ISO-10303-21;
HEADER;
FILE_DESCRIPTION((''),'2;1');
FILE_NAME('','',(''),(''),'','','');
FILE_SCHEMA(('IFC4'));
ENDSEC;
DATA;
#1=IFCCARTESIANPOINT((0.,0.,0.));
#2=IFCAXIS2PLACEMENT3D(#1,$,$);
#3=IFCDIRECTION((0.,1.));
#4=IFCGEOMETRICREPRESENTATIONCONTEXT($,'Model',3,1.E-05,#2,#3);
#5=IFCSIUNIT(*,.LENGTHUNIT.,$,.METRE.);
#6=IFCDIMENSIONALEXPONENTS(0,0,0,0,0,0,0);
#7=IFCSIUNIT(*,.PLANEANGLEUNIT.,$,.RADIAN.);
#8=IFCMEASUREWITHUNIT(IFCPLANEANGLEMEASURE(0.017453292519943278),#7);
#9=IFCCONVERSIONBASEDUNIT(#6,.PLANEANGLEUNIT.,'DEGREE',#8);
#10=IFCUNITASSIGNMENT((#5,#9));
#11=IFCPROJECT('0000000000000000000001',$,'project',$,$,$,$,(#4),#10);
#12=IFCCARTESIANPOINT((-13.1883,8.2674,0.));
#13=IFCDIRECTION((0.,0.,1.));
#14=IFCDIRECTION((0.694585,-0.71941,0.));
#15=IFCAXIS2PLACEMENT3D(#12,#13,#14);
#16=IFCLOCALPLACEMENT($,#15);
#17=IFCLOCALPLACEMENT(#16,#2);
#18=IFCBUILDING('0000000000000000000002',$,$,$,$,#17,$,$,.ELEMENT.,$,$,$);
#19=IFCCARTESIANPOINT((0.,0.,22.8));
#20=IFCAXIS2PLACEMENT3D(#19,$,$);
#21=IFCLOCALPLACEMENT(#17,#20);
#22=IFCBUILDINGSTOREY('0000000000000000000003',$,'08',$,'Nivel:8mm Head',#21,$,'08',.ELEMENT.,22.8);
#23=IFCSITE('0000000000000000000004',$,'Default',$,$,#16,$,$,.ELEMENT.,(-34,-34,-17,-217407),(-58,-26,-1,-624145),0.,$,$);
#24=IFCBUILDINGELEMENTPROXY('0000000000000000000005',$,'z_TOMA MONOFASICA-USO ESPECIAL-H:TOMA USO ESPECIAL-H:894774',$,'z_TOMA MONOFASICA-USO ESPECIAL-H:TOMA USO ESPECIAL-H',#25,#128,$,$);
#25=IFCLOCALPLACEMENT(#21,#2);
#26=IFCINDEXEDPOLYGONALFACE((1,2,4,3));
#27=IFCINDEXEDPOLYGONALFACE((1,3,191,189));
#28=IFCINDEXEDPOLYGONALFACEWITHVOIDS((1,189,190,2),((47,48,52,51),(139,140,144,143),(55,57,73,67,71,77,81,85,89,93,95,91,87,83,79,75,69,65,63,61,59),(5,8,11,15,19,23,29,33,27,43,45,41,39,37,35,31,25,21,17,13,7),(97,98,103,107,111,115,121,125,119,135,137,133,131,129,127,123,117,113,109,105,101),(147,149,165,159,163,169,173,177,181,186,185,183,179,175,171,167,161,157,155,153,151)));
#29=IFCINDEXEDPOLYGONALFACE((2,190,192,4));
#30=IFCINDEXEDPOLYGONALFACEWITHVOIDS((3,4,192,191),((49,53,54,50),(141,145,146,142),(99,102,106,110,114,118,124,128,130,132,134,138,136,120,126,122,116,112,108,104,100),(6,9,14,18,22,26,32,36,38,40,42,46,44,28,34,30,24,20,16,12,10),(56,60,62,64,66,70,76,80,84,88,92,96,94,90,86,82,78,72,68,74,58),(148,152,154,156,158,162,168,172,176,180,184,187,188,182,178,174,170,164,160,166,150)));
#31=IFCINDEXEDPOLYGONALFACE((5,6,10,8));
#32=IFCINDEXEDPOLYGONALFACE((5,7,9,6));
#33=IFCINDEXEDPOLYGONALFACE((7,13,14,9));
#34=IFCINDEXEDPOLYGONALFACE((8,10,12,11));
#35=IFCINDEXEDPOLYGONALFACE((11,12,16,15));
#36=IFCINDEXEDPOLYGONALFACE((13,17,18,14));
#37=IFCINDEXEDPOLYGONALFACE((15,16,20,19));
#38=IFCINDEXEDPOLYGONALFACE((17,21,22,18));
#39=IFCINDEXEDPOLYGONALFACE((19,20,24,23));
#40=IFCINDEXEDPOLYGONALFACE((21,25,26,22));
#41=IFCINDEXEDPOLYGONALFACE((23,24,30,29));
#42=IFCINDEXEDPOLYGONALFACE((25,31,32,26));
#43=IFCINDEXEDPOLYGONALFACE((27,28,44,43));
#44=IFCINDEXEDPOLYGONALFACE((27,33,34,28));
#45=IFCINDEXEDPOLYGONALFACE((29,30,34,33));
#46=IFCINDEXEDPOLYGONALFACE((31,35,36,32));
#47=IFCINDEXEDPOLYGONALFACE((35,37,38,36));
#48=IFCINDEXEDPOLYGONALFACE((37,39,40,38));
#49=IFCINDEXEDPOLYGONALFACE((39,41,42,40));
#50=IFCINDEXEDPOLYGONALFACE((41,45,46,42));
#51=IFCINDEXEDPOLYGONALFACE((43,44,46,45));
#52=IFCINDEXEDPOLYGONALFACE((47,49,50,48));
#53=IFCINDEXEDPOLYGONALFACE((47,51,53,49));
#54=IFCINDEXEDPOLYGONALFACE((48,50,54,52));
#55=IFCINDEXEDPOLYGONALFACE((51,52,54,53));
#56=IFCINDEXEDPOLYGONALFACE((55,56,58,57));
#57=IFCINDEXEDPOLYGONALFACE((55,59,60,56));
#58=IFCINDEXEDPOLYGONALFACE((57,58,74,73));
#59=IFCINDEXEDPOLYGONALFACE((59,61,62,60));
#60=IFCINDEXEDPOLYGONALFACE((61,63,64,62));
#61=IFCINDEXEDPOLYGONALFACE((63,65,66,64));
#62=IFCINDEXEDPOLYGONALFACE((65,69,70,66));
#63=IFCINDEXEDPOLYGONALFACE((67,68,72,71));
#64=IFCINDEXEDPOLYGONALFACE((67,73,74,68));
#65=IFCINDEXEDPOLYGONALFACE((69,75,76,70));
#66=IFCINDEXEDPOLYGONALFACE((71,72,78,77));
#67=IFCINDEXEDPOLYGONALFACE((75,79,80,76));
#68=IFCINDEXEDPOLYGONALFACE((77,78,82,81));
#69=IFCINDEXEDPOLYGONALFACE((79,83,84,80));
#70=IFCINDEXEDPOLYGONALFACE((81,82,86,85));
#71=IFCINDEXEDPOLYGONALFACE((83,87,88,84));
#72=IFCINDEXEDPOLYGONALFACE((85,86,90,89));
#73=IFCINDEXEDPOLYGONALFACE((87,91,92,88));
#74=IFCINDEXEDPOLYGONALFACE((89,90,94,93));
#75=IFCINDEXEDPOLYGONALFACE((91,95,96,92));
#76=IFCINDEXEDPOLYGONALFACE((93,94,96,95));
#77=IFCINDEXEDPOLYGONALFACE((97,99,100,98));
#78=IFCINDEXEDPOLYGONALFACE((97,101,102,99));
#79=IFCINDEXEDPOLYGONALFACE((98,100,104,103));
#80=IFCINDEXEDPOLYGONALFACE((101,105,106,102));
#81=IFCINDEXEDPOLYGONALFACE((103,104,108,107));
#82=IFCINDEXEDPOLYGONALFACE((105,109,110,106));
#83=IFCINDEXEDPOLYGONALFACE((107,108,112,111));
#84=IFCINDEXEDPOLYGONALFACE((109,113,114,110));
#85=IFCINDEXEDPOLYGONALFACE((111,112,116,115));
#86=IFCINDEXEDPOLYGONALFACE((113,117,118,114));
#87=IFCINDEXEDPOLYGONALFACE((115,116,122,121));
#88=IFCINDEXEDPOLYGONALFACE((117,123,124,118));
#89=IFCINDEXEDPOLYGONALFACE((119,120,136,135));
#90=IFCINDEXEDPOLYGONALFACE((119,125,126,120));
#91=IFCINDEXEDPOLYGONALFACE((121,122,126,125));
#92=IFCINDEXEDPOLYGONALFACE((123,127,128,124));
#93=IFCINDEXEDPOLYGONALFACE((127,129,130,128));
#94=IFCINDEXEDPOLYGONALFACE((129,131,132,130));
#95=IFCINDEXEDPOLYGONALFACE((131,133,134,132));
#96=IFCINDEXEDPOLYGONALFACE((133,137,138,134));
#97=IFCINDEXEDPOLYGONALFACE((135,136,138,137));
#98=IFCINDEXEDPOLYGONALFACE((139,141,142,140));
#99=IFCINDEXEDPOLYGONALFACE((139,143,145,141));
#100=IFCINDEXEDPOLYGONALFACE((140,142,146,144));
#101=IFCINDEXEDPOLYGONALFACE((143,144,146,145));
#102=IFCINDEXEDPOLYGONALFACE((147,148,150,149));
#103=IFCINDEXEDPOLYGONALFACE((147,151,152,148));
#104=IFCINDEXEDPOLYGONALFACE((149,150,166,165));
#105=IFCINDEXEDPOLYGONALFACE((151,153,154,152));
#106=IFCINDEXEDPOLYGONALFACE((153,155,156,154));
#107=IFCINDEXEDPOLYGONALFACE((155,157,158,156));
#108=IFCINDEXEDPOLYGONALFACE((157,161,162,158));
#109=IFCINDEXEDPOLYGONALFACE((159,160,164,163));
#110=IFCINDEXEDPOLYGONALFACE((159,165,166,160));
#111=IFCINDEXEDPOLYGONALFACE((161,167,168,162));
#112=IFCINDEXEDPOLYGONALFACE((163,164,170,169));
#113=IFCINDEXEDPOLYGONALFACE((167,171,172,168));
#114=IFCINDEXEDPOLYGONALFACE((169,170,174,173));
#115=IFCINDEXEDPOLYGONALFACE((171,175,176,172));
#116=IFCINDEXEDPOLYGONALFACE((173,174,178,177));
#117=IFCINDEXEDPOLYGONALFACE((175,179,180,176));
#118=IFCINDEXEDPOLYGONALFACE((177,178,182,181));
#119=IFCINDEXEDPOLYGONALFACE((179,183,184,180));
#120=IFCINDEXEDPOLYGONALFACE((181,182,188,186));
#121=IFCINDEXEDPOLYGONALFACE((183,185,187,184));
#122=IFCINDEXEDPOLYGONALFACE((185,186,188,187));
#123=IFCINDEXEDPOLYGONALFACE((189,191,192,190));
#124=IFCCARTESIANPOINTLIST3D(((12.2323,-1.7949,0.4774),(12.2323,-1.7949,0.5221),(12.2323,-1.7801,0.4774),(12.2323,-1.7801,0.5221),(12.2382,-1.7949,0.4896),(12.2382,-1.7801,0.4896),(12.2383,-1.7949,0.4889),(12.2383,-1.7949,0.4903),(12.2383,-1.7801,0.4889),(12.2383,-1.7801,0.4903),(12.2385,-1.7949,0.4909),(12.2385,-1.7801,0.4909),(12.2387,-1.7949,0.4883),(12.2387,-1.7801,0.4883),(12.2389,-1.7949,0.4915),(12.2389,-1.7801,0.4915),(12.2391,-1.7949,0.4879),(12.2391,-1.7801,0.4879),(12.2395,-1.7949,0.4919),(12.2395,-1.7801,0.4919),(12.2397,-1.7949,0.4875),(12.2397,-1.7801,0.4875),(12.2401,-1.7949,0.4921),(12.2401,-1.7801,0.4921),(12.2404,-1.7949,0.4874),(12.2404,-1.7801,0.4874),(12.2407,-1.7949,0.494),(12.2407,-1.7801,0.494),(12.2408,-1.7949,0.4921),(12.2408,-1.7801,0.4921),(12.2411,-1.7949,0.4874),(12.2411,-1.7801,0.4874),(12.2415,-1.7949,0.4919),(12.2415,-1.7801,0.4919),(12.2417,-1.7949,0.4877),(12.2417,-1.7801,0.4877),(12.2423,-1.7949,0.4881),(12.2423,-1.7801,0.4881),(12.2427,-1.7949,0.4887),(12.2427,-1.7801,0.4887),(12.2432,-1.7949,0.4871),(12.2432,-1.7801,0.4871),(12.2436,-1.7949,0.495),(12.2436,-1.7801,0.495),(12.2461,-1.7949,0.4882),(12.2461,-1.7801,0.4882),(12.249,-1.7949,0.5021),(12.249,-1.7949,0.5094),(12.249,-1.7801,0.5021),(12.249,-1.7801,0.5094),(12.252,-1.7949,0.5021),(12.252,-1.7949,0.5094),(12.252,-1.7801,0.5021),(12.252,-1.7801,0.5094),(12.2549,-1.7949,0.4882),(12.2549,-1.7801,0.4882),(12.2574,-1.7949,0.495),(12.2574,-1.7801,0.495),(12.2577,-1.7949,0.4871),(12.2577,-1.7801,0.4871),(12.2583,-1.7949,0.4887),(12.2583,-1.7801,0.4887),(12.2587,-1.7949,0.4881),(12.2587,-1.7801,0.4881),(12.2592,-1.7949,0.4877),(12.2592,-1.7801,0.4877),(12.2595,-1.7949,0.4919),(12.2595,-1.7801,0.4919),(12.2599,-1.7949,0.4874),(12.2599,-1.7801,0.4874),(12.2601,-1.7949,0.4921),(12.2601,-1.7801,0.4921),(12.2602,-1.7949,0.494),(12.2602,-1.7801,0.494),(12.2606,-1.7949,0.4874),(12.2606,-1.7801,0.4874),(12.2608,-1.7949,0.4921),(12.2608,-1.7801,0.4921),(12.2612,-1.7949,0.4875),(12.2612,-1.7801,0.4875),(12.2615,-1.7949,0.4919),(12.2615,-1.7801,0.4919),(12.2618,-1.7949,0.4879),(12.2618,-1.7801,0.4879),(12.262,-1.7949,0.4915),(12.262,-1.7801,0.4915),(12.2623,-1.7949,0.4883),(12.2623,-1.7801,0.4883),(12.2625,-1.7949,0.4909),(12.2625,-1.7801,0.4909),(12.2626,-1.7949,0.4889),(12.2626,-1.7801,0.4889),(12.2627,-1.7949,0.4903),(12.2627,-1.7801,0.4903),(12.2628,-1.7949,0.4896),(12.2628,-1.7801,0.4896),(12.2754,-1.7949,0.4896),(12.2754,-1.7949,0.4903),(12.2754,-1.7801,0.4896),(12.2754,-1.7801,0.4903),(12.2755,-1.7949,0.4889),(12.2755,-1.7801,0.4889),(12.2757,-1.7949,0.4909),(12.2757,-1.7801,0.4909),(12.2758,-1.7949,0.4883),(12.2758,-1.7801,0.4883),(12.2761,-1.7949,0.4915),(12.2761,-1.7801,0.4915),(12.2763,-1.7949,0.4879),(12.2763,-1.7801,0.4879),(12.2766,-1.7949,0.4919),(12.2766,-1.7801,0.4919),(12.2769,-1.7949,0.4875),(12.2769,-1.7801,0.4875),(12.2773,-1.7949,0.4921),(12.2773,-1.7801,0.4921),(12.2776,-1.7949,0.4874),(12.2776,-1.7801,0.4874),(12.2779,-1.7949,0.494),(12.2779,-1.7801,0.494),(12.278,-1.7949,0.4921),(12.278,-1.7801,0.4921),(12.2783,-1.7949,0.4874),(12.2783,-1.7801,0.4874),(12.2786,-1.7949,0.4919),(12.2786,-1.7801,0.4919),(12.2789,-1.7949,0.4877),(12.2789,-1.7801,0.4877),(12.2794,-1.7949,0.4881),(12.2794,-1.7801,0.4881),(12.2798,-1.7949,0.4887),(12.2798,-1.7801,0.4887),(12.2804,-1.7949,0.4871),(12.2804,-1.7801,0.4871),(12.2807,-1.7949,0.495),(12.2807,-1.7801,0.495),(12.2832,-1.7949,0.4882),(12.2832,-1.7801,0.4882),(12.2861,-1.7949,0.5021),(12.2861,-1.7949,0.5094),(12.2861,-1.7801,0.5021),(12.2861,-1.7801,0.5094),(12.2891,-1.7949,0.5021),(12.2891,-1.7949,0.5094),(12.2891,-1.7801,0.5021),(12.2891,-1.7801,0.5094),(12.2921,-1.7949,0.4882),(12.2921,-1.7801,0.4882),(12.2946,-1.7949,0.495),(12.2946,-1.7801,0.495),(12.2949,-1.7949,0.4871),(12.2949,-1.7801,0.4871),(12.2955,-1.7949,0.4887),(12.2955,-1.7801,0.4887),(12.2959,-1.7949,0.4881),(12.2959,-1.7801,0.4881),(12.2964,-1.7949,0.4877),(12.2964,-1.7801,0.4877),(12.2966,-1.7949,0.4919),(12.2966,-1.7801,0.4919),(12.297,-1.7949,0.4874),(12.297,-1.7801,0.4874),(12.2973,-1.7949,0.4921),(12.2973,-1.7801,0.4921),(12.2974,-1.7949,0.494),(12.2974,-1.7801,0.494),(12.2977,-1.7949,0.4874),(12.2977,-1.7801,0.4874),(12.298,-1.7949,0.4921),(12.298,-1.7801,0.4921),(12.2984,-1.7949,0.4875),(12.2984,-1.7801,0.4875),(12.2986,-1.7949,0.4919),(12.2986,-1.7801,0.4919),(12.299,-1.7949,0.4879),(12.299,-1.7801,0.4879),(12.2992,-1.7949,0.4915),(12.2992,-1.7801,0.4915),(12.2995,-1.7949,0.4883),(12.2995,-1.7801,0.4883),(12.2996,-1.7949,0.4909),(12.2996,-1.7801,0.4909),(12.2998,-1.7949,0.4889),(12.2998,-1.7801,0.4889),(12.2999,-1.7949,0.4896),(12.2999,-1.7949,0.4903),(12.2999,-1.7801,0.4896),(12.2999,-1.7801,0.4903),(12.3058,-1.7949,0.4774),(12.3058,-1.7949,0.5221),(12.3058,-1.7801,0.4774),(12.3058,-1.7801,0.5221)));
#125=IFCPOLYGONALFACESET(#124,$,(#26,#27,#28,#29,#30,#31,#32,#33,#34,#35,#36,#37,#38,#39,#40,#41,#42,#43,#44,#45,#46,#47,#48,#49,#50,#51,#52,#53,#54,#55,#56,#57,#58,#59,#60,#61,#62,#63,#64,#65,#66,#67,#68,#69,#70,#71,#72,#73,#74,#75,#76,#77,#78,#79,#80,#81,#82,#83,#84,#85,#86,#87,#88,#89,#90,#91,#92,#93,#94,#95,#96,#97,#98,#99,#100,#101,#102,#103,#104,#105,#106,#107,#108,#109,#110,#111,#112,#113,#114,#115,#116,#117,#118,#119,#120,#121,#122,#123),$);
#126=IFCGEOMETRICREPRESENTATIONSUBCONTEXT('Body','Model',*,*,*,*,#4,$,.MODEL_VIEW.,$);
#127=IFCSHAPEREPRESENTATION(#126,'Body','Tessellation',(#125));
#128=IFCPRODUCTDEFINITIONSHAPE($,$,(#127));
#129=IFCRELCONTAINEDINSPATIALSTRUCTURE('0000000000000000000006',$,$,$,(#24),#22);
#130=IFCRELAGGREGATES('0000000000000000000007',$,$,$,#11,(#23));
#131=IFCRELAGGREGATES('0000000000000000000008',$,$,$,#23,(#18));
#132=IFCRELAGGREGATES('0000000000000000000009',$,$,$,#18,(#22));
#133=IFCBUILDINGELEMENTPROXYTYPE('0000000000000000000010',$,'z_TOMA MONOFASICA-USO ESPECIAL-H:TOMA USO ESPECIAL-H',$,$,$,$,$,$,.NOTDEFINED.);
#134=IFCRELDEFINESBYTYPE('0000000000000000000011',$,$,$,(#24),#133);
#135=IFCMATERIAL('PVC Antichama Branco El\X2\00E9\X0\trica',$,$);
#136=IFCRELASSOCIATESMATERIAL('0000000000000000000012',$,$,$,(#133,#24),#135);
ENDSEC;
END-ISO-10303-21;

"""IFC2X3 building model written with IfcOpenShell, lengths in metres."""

from ifc_helpers import new_model, entity, si_unit, converted_unit, direction, frame, frame_2d, origin, place, context, subcontext, project, spatial, polyline, circle_curve, parameter, trimmed, segment, composite_curve, outline, extrude, source, transform, mapped, material, type_object, type_shapes, element, save


model = new_model("IFC2X3")

# Units and contexts
model_context = context("Model", 3, precision=1e-05, world=origin(), true_north=direction((0.0, 1.0)))
body_context = subcontext(model_context, "Body", "Model", "MODEL_VIEW")
ifc_project = project(units=[si_unit("LENGTHUNIT", "METRE"), converted_unit("PLANEANGLEUNIT", "DEGREE", entity("IfcPlaneAngleMeasure", 0.017453292519943278), si_unit("PLANEANGLEUNIT", "RADIAN"), dimensions=[0, 0, 0, 0, 0, 0, 0])], contexts=[model_context])

# Site, building, storey
site_placement = place(None, frame((-13.1883, 8.2674, 0.0), z_axis=(0.0, 0.0, 1.0), x_axis=(0.694585, -0.71941, 0.0)))
site = spatial("IfcSite", under=ifc_project, at=site_placement, Name="Default", CompositionType="ELEMENT", RefLatitude=(-34, -34, -17, -217407), RefLongitude=(-58, -26, -1, -624145), RefElevation=0.0)
building_placement = place(site_placement, origin())
building = spatial("IfcBuilding", under=site, at=building_placement, CompositionType="ELEMENT")
storey_placement = place(building_placement, frame((0.0, 0.0, 22.8)))
storey = spatial("IfcBuildingStorey", under=building, at=storey_placement, Name="08", ObjectType="Nivel:8mm Head", LongName="08", CompositionType="ELEMENT", Elevation=22.8)

# Building element proxy
ifc_material_1 = material(Name="PVC Antichama Branco Elétrica")
building_element_proxy_type_1 = type_object("IfcBuildingElementProxyType", Name="z_TOMA MONOFASICA-USO ESPECIAL-H:TOMA USO ESPECIAL-H", PredefinedType="NOTDEFINED", material=ifc_material_1)
shared_shape_1 = source(origin(), body_context, "Body", "SweptSolid", [
    extrude(outline(polyline([(-0.0368, -0.0223), (0.0368, -0.0223), (0.0368, 0.0223), (-0.0368, 0.0223), (-0.0368, -0.0223)]), holes=[composite_curve([segment(polyline([(0.0141, 0.0115), (0.0116, 0.0047)]), True, "CONTINUOUS"), segment(polyline([(0.0116, 0.0047), (0.0088, 0.0057)]), True, "CONTINUOUS"), segment(polyline([(0.0088, 0.0057), (0.0096, 0.0078)]), True, "CONTINUOUS"), segment(trimmed(circle_curve(frame_2d((0.0087, 0.0099), x_axis=(1.0, 0.0)), 0.0024), [parameter(27.118901)], [parameter(292.881099)], True, "PARAMETER"), False, "CONTINUOUS"), segment(polyline([(0.0108, 0.011), (0.0113, 0.0126)]), True, "CONTINUOUS"), segment(polyline([(0.0113, 0.0126), (0.0141, 0.0115)]), True, "CONTINUOUS")], self_intersect=False), composite_curve([segment(polyline([(0.0255, 0.0047), (0.023, 0.0115)]), True, "CONTINUOUS"), segment(polyline([(0.023, 0.0115), (0.0258, 0.0126)]), True, "CONTINUOUS"), segment(polyline([(0.0258, 0.0126), (0.0264, 0.011)]), True, "CONTINUOUS"), segment(trimmed(circle_curve(frame_2d((0.0285, 0.0099), x_axis=(1.0, 0.0)), 0.0024), [parameter(247.118901)], [parameter(152.881099)], True, "PARAMETER"), False, "CONTINUOUS"), segment(polyline([(0.0276, 0.0078), (0.0283, 0.0057)]), True, "CONTINUOUS"), segment(polyline([(0.0283, 0.0057), (0.0255, 0.0047)]), True, "CONTINUOUS")], self_intersect=False), polyline([(0.0201, -0.0024), (0.0201, -0.0097), (0.0171, -0.0097), (0.0171, -0.0024), (0.0201, -0.0024)]), composite_curve([segment(polyline([(-0.0141, 0.0115), (-0.0113, 0.0126)]), True, "CONTINUOUS"), segment(polyline([(-0.0113, 0.0126), (-0.0108, 0.011)]), True, "CONTINUOUS"), segment(trimmed(circle_curve(frame_2d((-0.0087, 0.0099), x_axis=(1.0, 0.0)), 0.0024), [parameter(247.118901)], [parameter(152.881099)], True, "PARAMETER"), False, "CONTINUOUS"), segment(polyline([(-0.0096, 0.0078), (-0.0088, 0.0057)]), True, "CONTINUOUS"), segment(polyline([(-0.0088, 0.0057), (-0.0116, 0.0047)]), True, "CONTINUOUS"), segment(polyline([(-0.0116, 0.0047), (-0.0141, 0.0115)]), True, "CONTINUOUS")], self_intersect=False), composite_curve([segment(polyline([(-0.0255, 0.0047), (-0.0283, 0.0057)]), True, "CONTINUOUS"), segment(polyline([(-0.0283, 0.0057), (-0.0276, 0.0078)]), True, "CONTINUOUS"), segment(trimmed(circle_curve(frame_2d((-0.0285, 0.0099), x_axis=(1.0, 0.0)), 0.0024), [parameter(27.118901)], [parameter(292.881099)], True, "PARAMETER"), False, "CONTINUOUS"), segment(polyline([(-0.0264, 0.011), (-0.0258, 0.0126)]), True, "CONTINUOUS"), segment(polyline([(-0.0258, 0.0126), (-0.023, 0.0115)]), True, "CONTINUOUS"), segment(polyline([(-0.023, 0.0115), (-0.0255, 0.0047)]), True, "CONTINUOUS")], self_intersect=False), polyline([(-0.0201, -0.0024), (-0.0171, -0.0024), (-0.0171, -0.0097), (-0.0201, -0.0097), (-0.0201, -0.0024)])]), frame((0.0, -0.005, 0.0223), z_axis=(0.0, 1.0, 0.0), x_axis=(1.0, 0.0, 0.0)), (0.0, 0.0, 1.0), 0.0148),
])
type_shapes(building_element_proxy_type_1, [shared_shape_1])
proxy_1_placement = place(storey_placement, frame((12.2691, -1.7851, 0.4774), z_axis=(0.0, 0.0, 1.0), x_axis=(-1.0, 0.0, 0.0)))
element("IfcBuildingElementProxy", 1, at=proxy_1_placement, inside=storey, type_object=building_element_proxy_type_1, material=ifc_material_1, Name="z_TOMA MONOFASICA-USO ESPECIAL-H:TOMA USO ESPECIAL-H:894774", ObjectType="z_TOMA MONOFASICA-USO ESPECIAL-H:TOMA USO ESPECIAL-H", context=body_context, shape_type="MappedRepresentation", body=[
    mapped(shared_shape_1, transform((0.0, 0.0, 0.0), scale=1.0)),
])

save(model, "model.ifc")
